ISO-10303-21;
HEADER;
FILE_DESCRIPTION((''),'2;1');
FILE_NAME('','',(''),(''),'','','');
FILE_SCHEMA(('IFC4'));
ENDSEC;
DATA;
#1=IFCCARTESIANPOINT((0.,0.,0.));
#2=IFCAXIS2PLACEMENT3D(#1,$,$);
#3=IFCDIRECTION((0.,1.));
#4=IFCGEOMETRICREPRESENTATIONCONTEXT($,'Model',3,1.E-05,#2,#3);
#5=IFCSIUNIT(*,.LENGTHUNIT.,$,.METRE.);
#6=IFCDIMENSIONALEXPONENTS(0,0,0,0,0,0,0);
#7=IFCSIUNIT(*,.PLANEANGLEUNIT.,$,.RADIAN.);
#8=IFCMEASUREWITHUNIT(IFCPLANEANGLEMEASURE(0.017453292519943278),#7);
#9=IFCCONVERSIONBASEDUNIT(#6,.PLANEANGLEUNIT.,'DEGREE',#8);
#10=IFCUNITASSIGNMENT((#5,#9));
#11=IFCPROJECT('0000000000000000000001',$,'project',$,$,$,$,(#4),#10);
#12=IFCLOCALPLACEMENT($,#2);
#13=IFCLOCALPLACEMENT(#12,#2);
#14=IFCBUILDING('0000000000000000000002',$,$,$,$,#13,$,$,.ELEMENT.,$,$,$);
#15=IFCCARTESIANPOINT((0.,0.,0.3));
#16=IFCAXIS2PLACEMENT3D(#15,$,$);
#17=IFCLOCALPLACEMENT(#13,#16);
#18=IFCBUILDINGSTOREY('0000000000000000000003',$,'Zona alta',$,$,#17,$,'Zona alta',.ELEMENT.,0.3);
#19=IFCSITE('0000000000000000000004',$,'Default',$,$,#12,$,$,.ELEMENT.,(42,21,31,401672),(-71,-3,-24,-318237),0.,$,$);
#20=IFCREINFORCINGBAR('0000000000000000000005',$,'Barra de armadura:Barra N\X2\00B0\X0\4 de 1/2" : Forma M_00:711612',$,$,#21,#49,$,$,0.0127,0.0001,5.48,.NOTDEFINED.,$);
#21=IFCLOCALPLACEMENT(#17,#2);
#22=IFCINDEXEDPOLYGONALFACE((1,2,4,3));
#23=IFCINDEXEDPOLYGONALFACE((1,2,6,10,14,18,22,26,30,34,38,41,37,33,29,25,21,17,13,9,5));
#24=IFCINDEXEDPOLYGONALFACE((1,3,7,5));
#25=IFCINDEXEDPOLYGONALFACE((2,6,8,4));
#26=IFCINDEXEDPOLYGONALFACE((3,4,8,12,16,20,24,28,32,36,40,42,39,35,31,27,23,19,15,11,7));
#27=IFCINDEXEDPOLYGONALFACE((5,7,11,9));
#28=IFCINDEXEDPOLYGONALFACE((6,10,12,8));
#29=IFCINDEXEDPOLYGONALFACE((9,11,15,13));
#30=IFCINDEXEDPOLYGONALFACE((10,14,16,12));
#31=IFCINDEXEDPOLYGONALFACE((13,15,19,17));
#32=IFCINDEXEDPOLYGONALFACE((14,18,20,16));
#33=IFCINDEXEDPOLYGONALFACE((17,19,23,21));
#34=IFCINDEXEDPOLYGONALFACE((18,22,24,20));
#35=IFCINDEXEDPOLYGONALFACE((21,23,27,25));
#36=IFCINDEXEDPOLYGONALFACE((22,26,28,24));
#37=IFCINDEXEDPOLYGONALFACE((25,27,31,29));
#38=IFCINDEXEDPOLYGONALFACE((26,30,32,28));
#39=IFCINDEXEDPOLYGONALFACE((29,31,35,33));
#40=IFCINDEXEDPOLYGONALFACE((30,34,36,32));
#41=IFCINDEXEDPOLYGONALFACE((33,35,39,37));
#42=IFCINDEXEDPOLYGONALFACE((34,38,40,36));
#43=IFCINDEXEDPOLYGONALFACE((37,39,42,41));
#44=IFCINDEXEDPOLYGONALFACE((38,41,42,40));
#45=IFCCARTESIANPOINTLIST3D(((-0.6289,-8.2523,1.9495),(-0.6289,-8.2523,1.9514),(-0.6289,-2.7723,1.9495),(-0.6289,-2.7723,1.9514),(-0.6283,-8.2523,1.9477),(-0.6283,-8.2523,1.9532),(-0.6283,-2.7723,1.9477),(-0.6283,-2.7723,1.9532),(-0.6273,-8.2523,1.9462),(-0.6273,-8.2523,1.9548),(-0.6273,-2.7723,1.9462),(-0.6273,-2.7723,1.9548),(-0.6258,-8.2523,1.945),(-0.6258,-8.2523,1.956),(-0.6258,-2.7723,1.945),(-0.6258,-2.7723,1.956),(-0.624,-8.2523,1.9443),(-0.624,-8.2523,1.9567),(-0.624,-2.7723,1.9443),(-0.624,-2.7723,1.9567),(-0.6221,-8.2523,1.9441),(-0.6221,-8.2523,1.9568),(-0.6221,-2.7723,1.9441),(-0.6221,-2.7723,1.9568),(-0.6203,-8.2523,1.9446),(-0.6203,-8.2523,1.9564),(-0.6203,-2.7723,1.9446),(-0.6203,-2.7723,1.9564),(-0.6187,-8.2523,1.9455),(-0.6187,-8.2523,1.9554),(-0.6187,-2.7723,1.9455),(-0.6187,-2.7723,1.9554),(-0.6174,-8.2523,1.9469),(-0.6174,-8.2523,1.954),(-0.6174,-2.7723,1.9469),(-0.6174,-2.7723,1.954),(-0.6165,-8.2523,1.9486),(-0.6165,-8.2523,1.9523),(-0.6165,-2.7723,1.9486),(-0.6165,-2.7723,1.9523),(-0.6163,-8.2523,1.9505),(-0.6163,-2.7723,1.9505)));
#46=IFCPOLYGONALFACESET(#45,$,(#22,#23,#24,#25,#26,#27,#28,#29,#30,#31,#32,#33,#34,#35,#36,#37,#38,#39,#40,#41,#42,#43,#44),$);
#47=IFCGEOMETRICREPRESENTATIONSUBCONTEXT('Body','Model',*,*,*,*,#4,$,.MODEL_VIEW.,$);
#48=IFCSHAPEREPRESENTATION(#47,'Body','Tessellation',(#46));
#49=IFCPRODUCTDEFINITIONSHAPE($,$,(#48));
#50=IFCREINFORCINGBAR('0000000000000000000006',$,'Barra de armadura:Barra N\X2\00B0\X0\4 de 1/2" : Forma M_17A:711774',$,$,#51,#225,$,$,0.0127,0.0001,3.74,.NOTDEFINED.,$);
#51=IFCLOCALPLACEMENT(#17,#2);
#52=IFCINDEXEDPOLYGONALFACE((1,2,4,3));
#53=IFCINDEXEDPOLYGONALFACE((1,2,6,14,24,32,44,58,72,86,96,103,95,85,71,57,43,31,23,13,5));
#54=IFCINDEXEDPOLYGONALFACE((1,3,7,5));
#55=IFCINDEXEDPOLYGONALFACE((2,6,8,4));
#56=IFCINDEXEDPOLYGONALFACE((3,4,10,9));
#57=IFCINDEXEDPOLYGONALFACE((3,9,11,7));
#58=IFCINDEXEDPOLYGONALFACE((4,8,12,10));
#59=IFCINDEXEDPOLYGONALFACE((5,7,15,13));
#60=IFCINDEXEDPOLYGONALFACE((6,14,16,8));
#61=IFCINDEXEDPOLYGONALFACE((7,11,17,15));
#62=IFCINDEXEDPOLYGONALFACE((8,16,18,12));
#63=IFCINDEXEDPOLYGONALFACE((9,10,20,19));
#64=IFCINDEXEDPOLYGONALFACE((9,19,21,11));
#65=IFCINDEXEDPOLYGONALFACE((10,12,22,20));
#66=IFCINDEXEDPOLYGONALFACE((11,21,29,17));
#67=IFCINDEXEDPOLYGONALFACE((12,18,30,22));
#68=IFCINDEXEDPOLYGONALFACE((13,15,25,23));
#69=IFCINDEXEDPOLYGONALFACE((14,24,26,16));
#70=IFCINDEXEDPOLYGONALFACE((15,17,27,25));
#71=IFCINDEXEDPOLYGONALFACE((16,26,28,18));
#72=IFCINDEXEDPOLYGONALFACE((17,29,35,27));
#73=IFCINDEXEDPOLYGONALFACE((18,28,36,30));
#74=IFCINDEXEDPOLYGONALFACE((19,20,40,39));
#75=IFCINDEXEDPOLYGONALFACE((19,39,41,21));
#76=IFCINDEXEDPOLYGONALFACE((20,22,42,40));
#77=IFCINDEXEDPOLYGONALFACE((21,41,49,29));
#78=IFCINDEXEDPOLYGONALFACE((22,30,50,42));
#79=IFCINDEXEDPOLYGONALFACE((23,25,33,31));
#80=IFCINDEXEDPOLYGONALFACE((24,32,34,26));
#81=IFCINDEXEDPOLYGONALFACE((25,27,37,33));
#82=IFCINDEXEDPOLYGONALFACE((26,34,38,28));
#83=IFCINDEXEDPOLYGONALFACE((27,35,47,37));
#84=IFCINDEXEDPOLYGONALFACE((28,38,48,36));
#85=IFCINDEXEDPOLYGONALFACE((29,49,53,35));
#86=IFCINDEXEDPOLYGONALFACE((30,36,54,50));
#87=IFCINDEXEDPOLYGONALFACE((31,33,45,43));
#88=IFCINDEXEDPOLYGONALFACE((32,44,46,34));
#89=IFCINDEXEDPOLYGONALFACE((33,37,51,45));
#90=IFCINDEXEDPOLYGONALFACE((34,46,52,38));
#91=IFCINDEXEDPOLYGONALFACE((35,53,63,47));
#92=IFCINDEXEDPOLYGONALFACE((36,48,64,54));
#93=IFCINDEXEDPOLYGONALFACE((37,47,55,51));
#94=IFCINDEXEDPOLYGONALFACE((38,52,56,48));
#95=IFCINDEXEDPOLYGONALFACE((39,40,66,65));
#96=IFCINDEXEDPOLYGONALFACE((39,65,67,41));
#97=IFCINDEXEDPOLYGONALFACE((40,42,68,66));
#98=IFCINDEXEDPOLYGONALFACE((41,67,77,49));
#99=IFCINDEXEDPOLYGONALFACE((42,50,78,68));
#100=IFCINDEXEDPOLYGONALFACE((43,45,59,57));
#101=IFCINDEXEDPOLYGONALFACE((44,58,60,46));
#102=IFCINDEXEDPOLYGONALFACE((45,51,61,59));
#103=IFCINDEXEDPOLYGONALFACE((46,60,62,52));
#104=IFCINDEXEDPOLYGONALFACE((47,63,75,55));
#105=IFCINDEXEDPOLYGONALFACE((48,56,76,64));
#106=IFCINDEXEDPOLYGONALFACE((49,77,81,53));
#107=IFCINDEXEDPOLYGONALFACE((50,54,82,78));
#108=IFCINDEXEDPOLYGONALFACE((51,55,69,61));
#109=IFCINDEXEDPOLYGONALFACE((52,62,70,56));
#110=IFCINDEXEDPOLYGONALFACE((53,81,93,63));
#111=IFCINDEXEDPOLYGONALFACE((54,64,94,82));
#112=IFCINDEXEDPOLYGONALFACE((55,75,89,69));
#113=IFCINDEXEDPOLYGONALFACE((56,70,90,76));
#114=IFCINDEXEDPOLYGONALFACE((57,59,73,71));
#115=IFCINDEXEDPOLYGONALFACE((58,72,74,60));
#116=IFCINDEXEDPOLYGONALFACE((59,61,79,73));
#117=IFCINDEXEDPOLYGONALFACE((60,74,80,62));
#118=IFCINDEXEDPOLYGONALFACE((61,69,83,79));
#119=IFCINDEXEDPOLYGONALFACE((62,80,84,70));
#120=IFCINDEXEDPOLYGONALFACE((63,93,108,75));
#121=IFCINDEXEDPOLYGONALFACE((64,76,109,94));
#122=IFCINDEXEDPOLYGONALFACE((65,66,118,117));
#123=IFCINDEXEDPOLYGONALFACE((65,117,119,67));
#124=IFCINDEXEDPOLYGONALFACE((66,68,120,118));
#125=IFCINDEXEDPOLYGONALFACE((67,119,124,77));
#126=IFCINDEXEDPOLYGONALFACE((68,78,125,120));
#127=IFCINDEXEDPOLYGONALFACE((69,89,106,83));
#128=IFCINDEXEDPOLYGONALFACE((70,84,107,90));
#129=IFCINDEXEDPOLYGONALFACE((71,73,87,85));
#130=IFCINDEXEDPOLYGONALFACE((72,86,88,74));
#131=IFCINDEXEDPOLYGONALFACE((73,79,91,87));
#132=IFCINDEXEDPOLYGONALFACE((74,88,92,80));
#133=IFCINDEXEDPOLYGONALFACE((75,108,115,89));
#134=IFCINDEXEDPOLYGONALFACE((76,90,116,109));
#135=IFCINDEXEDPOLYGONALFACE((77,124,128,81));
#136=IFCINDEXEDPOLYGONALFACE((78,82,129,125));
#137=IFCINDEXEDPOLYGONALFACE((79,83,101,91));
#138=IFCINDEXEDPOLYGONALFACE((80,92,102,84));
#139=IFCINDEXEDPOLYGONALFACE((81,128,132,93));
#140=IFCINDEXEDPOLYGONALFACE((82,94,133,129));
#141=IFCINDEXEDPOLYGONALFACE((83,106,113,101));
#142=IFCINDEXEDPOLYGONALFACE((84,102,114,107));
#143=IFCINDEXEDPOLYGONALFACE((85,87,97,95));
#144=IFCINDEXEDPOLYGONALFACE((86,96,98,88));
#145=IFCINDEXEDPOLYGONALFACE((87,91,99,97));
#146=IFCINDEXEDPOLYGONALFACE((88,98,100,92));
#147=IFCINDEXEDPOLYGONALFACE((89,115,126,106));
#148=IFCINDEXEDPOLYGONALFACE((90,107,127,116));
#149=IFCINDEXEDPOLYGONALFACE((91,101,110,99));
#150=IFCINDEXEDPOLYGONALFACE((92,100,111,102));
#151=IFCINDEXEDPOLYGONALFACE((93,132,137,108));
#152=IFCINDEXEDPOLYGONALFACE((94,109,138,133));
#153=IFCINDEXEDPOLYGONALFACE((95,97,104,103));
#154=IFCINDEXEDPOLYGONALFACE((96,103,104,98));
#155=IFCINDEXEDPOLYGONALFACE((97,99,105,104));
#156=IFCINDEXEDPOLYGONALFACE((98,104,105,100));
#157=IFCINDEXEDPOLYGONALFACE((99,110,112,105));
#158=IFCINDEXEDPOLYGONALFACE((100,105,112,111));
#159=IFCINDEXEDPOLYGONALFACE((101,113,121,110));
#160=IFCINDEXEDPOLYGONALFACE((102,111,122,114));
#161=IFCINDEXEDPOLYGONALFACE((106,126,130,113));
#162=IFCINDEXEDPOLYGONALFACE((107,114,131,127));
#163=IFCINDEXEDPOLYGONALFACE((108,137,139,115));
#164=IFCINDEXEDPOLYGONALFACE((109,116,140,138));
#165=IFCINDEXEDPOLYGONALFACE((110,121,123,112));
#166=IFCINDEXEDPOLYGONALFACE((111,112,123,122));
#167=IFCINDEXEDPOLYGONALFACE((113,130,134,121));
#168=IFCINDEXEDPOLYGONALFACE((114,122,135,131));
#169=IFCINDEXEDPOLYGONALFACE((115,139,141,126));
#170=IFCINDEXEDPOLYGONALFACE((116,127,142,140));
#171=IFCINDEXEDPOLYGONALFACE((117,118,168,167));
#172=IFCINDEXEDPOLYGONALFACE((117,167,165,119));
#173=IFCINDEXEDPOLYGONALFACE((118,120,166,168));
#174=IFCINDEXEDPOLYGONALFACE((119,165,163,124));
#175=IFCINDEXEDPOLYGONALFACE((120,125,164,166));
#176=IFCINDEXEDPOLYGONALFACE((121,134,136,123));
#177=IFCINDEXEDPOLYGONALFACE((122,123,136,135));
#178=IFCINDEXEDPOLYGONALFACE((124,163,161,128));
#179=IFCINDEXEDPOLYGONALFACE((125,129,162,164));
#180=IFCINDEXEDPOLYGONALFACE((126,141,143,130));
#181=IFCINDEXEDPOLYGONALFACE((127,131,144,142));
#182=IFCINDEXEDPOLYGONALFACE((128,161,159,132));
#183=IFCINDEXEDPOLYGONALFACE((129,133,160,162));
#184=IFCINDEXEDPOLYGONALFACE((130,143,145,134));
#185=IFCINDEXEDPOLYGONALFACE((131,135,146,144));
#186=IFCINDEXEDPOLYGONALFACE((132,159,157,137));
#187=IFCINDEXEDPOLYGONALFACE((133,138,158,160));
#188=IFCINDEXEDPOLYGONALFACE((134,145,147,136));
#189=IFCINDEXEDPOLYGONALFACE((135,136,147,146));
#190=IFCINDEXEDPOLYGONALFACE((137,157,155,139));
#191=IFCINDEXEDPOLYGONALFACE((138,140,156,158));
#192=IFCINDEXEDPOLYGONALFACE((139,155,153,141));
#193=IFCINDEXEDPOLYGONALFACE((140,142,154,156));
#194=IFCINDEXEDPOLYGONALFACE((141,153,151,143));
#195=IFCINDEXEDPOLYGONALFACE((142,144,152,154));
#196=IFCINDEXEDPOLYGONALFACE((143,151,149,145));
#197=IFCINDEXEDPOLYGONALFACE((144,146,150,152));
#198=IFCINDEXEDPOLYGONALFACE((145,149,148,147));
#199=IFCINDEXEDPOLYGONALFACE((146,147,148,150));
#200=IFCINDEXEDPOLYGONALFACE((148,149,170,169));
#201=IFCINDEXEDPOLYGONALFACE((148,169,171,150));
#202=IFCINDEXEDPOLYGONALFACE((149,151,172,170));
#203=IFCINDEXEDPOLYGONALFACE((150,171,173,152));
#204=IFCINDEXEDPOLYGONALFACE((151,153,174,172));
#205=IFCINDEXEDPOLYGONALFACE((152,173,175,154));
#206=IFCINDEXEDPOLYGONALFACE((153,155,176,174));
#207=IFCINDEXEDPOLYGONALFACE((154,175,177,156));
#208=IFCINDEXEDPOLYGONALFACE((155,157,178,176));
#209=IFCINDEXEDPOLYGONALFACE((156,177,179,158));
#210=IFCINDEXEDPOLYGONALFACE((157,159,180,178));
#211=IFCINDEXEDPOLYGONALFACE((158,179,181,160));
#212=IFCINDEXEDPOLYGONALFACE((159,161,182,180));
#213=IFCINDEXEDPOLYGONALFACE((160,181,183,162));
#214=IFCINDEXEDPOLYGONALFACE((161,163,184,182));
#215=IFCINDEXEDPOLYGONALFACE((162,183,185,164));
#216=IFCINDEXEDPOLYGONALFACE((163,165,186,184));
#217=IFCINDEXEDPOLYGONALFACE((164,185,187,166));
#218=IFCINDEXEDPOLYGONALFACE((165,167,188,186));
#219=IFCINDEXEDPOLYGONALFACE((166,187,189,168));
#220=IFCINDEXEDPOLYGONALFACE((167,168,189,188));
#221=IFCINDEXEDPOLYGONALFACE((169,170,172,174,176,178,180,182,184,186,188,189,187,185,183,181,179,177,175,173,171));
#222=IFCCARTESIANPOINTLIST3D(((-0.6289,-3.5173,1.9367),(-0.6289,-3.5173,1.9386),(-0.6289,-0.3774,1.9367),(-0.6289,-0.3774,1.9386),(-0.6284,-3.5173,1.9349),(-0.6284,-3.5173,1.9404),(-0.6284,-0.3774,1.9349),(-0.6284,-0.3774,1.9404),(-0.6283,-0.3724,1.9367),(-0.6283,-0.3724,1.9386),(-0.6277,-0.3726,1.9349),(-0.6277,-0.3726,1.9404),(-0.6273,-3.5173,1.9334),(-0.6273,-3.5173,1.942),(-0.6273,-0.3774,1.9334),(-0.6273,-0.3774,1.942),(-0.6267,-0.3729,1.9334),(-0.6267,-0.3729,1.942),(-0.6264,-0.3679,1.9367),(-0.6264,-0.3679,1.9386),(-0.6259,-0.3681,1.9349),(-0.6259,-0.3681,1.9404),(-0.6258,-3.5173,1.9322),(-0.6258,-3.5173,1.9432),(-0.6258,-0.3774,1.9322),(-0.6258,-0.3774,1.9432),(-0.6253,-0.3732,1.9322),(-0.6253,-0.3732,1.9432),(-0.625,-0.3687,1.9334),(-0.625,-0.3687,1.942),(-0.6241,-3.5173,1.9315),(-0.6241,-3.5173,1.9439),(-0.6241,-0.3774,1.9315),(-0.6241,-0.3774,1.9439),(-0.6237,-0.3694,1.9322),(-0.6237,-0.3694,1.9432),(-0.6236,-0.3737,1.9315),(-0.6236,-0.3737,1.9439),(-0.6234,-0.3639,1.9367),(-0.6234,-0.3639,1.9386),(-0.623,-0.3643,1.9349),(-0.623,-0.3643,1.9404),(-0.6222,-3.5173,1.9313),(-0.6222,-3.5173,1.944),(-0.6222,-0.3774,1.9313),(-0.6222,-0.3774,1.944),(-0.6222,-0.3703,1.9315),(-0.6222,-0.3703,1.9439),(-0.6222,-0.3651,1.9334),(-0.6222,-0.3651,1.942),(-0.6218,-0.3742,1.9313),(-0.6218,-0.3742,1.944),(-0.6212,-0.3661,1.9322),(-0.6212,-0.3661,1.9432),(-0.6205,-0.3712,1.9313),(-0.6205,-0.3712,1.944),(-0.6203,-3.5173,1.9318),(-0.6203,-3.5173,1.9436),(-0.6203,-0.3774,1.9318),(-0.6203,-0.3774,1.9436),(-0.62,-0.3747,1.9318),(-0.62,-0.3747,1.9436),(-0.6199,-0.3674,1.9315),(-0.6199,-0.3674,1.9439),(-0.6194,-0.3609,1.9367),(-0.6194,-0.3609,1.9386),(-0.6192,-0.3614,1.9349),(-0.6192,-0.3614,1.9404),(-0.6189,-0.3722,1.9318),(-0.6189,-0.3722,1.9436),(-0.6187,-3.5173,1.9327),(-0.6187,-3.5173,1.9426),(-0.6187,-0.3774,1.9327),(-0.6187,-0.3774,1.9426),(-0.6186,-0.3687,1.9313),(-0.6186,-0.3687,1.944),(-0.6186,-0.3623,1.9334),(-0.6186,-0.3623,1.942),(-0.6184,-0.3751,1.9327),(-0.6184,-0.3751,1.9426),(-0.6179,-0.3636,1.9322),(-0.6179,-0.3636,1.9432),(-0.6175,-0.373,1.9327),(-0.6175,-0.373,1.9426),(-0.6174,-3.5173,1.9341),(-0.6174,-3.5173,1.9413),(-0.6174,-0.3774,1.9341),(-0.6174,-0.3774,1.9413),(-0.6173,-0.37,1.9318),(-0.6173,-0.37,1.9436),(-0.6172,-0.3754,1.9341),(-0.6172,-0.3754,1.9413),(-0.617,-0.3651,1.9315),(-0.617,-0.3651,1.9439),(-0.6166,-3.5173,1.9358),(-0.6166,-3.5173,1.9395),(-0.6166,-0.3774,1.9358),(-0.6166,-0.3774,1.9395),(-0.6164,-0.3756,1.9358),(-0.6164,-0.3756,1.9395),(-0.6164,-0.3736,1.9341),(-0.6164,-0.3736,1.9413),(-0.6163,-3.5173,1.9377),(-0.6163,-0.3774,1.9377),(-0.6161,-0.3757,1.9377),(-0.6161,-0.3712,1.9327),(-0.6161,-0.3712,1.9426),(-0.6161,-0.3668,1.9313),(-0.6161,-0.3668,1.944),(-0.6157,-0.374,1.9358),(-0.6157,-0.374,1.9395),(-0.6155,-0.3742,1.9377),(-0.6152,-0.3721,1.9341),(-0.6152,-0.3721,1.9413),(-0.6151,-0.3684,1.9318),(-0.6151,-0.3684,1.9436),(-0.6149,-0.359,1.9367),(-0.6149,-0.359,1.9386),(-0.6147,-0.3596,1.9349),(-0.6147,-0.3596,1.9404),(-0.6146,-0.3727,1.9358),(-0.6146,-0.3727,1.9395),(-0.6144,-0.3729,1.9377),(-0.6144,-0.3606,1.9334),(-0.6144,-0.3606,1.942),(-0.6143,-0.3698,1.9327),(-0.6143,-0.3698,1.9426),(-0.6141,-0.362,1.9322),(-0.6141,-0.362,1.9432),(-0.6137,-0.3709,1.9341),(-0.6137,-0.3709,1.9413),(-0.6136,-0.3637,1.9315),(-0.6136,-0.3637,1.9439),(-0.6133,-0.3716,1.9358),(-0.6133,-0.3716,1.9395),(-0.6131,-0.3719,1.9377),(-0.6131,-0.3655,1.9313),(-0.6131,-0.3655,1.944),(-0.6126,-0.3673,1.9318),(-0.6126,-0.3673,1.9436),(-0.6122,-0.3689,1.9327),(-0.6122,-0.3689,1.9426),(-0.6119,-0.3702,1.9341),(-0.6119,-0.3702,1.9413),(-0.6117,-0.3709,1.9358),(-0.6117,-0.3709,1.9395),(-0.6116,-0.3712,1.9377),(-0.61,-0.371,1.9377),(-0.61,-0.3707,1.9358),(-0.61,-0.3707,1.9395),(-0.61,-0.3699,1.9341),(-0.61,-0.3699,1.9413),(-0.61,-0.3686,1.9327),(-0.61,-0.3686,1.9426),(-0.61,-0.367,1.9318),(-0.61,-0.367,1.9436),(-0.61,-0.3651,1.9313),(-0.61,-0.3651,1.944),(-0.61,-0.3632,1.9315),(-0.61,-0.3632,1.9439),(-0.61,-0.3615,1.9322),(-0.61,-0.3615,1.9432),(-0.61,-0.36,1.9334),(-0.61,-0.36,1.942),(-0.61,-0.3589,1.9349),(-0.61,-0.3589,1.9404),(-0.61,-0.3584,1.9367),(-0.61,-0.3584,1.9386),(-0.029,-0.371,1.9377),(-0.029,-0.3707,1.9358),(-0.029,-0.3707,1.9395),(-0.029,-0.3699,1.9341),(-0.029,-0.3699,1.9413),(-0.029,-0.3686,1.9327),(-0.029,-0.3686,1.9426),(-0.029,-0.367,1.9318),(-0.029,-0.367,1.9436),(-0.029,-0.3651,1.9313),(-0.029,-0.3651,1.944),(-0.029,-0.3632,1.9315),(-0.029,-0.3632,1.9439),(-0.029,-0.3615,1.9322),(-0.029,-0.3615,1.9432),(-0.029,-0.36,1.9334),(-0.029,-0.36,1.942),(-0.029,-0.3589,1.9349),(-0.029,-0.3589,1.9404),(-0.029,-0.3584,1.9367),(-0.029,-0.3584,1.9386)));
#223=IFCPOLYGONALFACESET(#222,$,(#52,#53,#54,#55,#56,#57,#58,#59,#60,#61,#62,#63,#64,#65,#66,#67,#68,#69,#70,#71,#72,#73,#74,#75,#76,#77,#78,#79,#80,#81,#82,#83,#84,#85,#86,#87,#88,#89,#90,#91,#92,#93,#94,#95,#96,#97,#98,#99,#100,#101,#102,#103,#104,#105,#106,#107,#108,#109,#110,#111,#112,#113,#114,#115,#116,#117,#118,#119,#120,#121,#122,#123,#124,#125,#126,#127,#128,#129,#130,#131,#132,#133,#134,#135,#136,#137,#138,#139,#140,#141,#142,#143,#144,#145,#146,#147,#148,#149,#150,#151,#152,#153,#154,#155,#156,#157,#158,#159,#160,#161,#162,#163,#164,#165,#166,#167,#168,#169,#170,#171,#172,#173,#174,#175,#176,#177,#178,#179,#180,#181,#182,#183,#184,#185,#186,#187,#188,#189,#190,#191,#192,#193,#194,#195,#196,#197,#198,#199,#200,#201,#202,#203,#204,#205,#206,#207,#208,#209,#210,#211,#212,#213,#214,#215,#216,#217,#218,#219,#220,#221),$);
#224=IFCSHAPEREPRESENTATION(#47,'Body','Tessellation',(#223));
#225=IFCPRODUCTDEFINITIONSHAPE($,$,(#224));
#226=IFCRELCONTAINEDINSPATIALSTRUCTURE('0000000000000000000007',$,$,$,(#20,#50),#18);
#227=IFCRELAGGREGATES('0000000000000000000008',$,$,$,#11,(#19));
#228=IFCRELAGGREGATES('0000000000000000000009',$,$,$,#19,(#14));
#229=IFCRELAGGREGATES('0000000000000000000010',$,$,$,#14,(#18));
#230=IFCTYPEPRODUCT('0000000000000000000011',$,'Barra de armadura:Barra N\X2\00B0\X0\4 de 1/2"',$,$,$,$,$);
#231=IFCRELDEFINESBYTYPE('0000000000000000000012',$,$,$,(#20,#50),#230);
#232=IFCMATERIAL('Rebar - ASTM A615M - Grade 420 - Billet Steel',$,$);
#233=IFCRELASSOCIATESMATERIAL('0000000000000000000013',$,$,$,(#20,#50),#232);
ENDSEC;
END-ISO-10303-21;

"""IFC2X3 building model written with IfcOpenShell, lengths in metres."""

from ifc_helpers import new_model, entity, si_unit, converted_unit, direction, frame, origin, place, context, subcontext, project, spatial, material, type_object, element, save


model = new_model("IFC2X3")

# Units and contexts
model_context = context("Model", 3, precision=1e-05, world=origin(), true_north=direction((0.0, 1.0)))
body_context = subcontext(model_context, "Body", "Model", "MODEL_VIEW")
ifc_project = project(units=[si_unit("LENGTHUNIT", "METRE"), converted_unit("PLANEANGLEUNIT", "DEGREE", entity("IfcPlaneAngleMeasure", 0.017453292519943278), si_unit("PLANEANGLEUNIT", "RADIAN"), dimensions=[0, 0, 0, 0, 0, 0, 0])], contexts=[model_context])

# Site, building, storey
site_placement = place(None, origin())
site = spatial("IfcSite", under=ifc_project, at=site_placement, Name="Default", CompositionType="ELEMENT", RefLatitude=(42, 21, 31, 401672), RefLongitude=(-71, -3, -24, -318237), RefElevation=0.0)
building_placement = place(site_placement, origin())
building = spatial("IfcBuilding", under=site, at=building_placement, CompositionType="ELEMENT")
storey_placement = place(building_placement, frame((0.0, 0.0, 0.3)))
storey = spatial("IfcBuildingStorey", under=building, at=storey_placement, Name="Zona alta", LongName="Zona alta", CompositionType="ELEMENT", Elevation=0.3)

# Reinforcing bars
ifc_material = material(Name="Rebar - ASTM A615M - Grade 420 - Billet Steel")
type_product_1 = type_object("IfcTypeProduct", Name="Barra de armadura:Barra N°4 de 1/2\"")
reinforcing_bar_1_placement = place(storey_placement, origin())
element("IfcReinforcingBar", 1, at=reinforcing_bar_1_placement, inside=storey, type_object=type_product_1, material=ifc_material, Name="Barra de armadura:Barra N°4 de 1/2\" : Forma M_00:711612", BarLength=5.48, BarRole="NOTDEFINED", CrossSectionArea=0.0001, NominalDiameter=0.0127, context=body_context, shape_type="AdvancedSweptSolid", body=[
    entity("IfcSweptDiskSolid", entity("IfcCompositeCurve", [entity("IfcCompositeCurveSegment", "CONTINUOUS", True, entity("IfcPolyline", [entity("IfcCartesianPoint", [-0.6226, -8.2523, 1.9505]), entity("IfcCartesianPoint", [-0.6226, -2.7723, 1.9505])]))], False), 0.0063, None, 0.0, 1.0),
])
reinforcing_bar_2_placement = place(storey_placement, origin())
element("IfcReinforcingBar", 2, at=reinforcing_bar_2_placement, inside=storey, type_object=type_product_1, material=ifc_material, Name="Barra de armadura:Barra N°4 de 1/2\" : Forma M_17A:711774", BarLength=3.74, BarRole="NOTDEFINED", CrossSectionArea=0.0001, NominalDiameter=0.0127, context=body_context, shape_type="AdvancedSweptSolid", body=[
    entity("IfcSweptDiskSolid", entity("IfcCompositeCurve", [entity("IfcCompositeCurveSegment", "CONTINUOUS", True, entity("IfcPolyline", [entity("IfcCartesianPoint", [-0.6227, -3.5173, 1.9377]), entity("IfcCartesianPoint", [-0.6227, -0.3774, 1.9377])])), entity("IfcCompositeCurveSegment", "CONTINUOUS", True, entity("IfcTrimmedCurve", entity("IfcCircle", entity("IfcAxis2Placement3D", entity("IfcCartesianPoint", [-0.61, -0.3774, 1.9377]), entity("IfcDirection", [0.0, 0.0, -1.0]), entity("IfcDirection", [0.0, 1.0, 0.0])), 0.0127), [entity("IfcParameterValue", 270.0)], [entity("IfcParameterValue", 360.0)], True, "PARAMETER")), entity("IfcCompositeCurveSegment", "CONTINUOUS", True, entity("IfcPolyline", [entity("IfcCartesianPoint", [-0.61, -0.3647, 1.9377]), entity("IfcCartesianPoint", [-0.029, -0.3647, 1.9377])]))], False), 0.0063, None, 0.0, 92.0),
])

save(model, "model.ifc")
